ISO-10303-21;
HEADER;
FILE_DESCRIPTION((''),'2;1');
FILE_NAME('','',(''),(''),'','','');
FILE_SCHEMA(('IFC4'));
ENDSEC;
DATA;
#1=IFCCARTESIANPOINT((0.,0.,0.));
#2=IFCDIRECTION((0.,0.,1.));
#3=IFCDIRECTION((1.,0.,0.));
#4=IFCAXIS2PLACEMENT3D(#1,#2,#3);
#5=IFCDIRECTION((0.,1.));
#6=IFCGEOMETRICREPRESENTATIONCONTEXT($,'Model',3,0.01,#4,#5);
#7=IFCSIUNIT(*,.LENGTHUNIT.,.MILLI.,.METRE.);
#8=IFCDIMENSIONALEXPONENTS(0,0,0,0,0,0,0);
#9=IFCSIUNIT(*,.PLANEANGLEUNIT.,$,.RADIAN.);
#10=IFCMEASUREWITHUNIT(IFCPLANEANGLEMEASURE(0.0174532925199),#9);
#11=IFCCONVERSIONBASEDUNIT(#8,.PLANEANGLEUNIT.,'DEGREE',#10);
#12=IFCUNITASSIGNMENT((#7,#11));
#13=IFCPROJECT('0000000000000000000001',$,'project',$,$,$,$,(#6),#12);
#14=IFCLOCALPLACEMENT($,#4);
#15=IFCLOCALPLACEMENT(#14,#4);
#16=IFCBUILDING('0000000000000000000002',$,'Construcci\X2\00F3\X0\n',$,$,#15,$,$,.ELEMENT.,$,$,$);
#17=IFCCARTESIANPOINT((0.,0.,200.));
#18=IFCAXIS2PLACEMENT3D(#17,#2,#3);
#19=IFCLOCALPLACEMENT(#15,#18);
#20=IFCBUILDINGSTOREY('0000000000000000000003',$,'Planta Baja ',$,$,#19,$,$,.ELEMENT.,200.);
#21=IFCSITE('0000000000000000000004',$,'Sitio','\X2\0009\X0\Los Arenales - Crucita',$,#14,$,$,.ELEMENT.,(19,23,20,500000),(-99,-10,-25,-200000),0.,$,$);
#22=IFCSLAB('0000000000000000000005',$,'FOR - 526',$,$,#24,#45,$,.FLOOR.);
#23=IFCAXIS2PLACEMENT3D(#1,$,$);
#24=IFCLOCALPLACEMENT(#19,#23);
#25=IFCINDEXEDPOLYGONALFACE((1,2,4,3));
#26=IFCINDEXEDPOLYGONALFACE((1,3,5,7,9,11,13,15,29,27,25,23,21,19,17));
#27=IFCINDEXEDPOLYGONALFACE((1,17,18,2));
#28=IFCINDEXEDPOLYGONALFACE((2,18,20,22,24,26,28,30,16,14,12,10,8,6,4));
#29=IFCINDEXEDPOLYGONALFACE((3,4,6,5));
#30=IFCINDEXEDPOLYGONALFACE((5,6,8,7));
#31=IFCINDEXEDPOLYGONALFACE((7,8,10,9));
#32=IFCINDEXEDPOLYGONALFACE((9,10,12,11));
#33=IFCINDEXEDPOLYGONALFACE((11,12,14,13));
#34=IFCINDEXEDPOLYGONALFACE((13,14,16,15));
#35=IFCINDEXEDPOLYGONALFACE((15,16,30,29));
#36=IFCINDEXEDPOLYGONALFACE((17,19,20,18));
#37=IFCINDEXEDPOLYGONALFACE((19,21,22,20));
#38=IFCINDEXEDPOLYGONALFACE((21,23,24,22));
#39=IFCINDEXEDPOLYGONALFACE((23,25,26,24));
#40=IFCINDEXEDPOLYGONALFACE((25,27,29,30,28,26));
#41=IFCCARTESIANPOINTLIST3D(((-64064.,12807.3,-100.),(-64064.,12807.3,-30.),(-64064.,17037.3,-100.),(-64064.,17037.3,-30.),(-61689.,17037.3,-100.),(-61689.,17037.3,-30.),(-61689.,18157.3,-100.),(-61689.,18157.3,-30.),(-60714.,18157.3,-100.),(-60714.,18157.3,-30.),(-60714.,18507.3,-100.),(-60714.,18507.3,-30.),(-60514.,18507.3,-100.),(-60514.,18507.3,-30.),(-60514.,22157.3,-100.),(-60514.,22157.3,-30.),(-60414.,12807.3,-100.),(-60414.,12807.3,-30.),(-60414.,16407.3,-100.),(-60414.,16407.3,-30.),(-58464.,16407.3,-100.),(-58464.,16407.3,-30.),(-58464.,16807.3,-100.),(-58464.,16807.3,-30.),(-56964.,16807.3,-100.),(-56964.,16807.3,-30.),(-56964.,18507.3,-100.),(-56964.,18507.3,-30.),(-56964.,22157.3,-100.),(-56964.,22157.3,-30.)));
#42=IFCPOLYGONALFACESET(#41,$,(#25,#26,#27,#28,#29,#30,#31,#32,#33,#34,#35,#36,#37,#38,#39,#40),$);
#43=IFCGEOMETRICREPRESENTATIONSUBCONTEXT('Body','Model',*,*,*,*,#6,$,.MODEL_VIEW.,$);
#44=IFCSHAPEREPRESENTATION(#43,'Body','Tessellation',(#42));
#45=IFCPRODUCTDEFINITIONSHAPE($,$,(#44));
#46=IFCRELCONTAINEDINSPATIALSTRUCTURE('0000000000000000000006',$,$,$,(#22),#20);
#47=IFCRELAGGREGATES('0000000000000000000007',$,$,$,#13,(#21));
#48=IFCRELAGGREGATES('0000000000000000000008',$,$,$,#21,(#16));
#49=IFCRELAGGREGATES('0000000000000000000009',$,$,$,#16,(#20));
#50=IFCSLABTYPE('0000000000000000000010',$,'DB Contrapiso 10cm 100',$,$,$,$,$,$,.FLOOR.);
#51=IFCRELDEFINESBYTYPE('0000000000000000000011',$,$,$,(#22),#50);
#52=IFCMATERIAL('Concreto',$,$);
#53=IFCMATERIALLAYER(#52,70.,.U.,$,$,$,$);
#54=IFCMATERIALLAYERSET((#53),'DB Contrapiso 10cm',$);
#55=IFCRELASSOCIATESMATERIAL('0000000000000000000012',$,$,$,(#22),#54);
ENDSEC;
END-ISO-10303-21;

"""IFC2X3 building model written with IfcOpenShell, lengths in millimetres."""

from ifc_helpers import new_model, entity, si_unit, converted_unit, direction, frame, origin_with_axes, place, context, subcontext, project, spatial, polyline, outline, extrude, material, layer, layer_set, layer_usage, type_object, element, save


model = new_model("IFC2X3")

# Units and contexts
model_context = context("Model", 3, precision=0.01, world=origin_with_axes(), true_north=direction((0.0, 1.0)))
body_context = subcontext(model_context, "Body", "Model", "MODEL_VIEW")
ifc_project = project(units=[si_unit("LENGTHUNIT", "METRE", prefix="MILLI"), converted_unit("PLANEANGLEUNIT", "DEGREE", entity("IfcPlaneAngleMeasure", 0.0174532925199), si_unit("PLANEANGLEUNIT", "RADIAN"), dimensions=[0, 0, 0, 0, 0, 0, 0])], contexts=[model_context])

# Site, building, storey
site_placement = place(None, origin_with_axes())
site = spatial("IfcSite", under=ifc_project, at=site_placement, Name="Sitio", Description="\tLos Arenales - Crucita", CompositionType="ELEMENT", RefLatitude=(19, 23, 20, 500000), RefLongitude=(-99, -10, -25, -200000), RefElevation=0.0)
building_placement = place(site_placement, origin_with_axes())
building = spatial("IfcBuilding", under=site, at=building_placement, Name="Construcción", CompositionType="ELEMENT")
storey_placement = place(building_placement, frame((0.0, 0.0, 200.0), z_axis=(0.0, 0.0, 1.0), x_axis=(1.0, 0.0, 0.0)))
storey = spatial("IfcBuildingStorey", under=building, at=storey_placement, Name="Planta Baja ", CompositionType="ELEMENT", Elevation=200.0)

# Slab
ifc_material = material(Name="Concreto")
ifc_layer = layer(ifc_material, 70.0, ventilated="UNKNOWN")
ifc_layer_set = layer_set([ifc_layer], Name="DB Contrapiso 10cm")
ifc_layer_usage = layer_usage(ifc_layer_set, "AXIS3", "NEGATIVE", 70.0)
slab_type = type_object("IfcSlabType", Name="DB Contrapiso 10cm 100", PredefinedType="FLOOR")
slab_placement = place(storey_placement, frame((-64064.0, 12807.3, 0.0), z_axis=(0.0, 0.0, 1.0), x_axis=(1.0, 0.0, 0.0)))
element("IfcSlab", 1, at=slab_placement, inside=storey, type_object=slab_type, material=ifc_layer_usage, Name="FOR - 526", PredefinedType="FLOOR", context=body_context, shape_type="SweptSolid", body=[
    extrude(outline(polyline([(0.0, 0.0), (3650.0, 0.0), (3650.0, 3600.0), (5600.0, 3600.0), (5600.0, 4000.0), (7100.0, 4000.0), (7100.0, 5700.0), (7100.0, 9350.0), (3550.0, 9350.0), (3550.0, 5700.0), (3350.0, 5700.0), (3350.0, 5350.0), (2375.0, 5350.0), (2375.0, 4230.0), (0.0, 4230.0), (0.0, 0.0)])), frame((0.0, 0.0, -100.0), z_axis=(0.0, 0.0, 1.0), x_axis=(1.0, 0.0, 0.0)), (0.0, 0.0, 1.0), 70.0),
])

save(model, "model.ifc")
